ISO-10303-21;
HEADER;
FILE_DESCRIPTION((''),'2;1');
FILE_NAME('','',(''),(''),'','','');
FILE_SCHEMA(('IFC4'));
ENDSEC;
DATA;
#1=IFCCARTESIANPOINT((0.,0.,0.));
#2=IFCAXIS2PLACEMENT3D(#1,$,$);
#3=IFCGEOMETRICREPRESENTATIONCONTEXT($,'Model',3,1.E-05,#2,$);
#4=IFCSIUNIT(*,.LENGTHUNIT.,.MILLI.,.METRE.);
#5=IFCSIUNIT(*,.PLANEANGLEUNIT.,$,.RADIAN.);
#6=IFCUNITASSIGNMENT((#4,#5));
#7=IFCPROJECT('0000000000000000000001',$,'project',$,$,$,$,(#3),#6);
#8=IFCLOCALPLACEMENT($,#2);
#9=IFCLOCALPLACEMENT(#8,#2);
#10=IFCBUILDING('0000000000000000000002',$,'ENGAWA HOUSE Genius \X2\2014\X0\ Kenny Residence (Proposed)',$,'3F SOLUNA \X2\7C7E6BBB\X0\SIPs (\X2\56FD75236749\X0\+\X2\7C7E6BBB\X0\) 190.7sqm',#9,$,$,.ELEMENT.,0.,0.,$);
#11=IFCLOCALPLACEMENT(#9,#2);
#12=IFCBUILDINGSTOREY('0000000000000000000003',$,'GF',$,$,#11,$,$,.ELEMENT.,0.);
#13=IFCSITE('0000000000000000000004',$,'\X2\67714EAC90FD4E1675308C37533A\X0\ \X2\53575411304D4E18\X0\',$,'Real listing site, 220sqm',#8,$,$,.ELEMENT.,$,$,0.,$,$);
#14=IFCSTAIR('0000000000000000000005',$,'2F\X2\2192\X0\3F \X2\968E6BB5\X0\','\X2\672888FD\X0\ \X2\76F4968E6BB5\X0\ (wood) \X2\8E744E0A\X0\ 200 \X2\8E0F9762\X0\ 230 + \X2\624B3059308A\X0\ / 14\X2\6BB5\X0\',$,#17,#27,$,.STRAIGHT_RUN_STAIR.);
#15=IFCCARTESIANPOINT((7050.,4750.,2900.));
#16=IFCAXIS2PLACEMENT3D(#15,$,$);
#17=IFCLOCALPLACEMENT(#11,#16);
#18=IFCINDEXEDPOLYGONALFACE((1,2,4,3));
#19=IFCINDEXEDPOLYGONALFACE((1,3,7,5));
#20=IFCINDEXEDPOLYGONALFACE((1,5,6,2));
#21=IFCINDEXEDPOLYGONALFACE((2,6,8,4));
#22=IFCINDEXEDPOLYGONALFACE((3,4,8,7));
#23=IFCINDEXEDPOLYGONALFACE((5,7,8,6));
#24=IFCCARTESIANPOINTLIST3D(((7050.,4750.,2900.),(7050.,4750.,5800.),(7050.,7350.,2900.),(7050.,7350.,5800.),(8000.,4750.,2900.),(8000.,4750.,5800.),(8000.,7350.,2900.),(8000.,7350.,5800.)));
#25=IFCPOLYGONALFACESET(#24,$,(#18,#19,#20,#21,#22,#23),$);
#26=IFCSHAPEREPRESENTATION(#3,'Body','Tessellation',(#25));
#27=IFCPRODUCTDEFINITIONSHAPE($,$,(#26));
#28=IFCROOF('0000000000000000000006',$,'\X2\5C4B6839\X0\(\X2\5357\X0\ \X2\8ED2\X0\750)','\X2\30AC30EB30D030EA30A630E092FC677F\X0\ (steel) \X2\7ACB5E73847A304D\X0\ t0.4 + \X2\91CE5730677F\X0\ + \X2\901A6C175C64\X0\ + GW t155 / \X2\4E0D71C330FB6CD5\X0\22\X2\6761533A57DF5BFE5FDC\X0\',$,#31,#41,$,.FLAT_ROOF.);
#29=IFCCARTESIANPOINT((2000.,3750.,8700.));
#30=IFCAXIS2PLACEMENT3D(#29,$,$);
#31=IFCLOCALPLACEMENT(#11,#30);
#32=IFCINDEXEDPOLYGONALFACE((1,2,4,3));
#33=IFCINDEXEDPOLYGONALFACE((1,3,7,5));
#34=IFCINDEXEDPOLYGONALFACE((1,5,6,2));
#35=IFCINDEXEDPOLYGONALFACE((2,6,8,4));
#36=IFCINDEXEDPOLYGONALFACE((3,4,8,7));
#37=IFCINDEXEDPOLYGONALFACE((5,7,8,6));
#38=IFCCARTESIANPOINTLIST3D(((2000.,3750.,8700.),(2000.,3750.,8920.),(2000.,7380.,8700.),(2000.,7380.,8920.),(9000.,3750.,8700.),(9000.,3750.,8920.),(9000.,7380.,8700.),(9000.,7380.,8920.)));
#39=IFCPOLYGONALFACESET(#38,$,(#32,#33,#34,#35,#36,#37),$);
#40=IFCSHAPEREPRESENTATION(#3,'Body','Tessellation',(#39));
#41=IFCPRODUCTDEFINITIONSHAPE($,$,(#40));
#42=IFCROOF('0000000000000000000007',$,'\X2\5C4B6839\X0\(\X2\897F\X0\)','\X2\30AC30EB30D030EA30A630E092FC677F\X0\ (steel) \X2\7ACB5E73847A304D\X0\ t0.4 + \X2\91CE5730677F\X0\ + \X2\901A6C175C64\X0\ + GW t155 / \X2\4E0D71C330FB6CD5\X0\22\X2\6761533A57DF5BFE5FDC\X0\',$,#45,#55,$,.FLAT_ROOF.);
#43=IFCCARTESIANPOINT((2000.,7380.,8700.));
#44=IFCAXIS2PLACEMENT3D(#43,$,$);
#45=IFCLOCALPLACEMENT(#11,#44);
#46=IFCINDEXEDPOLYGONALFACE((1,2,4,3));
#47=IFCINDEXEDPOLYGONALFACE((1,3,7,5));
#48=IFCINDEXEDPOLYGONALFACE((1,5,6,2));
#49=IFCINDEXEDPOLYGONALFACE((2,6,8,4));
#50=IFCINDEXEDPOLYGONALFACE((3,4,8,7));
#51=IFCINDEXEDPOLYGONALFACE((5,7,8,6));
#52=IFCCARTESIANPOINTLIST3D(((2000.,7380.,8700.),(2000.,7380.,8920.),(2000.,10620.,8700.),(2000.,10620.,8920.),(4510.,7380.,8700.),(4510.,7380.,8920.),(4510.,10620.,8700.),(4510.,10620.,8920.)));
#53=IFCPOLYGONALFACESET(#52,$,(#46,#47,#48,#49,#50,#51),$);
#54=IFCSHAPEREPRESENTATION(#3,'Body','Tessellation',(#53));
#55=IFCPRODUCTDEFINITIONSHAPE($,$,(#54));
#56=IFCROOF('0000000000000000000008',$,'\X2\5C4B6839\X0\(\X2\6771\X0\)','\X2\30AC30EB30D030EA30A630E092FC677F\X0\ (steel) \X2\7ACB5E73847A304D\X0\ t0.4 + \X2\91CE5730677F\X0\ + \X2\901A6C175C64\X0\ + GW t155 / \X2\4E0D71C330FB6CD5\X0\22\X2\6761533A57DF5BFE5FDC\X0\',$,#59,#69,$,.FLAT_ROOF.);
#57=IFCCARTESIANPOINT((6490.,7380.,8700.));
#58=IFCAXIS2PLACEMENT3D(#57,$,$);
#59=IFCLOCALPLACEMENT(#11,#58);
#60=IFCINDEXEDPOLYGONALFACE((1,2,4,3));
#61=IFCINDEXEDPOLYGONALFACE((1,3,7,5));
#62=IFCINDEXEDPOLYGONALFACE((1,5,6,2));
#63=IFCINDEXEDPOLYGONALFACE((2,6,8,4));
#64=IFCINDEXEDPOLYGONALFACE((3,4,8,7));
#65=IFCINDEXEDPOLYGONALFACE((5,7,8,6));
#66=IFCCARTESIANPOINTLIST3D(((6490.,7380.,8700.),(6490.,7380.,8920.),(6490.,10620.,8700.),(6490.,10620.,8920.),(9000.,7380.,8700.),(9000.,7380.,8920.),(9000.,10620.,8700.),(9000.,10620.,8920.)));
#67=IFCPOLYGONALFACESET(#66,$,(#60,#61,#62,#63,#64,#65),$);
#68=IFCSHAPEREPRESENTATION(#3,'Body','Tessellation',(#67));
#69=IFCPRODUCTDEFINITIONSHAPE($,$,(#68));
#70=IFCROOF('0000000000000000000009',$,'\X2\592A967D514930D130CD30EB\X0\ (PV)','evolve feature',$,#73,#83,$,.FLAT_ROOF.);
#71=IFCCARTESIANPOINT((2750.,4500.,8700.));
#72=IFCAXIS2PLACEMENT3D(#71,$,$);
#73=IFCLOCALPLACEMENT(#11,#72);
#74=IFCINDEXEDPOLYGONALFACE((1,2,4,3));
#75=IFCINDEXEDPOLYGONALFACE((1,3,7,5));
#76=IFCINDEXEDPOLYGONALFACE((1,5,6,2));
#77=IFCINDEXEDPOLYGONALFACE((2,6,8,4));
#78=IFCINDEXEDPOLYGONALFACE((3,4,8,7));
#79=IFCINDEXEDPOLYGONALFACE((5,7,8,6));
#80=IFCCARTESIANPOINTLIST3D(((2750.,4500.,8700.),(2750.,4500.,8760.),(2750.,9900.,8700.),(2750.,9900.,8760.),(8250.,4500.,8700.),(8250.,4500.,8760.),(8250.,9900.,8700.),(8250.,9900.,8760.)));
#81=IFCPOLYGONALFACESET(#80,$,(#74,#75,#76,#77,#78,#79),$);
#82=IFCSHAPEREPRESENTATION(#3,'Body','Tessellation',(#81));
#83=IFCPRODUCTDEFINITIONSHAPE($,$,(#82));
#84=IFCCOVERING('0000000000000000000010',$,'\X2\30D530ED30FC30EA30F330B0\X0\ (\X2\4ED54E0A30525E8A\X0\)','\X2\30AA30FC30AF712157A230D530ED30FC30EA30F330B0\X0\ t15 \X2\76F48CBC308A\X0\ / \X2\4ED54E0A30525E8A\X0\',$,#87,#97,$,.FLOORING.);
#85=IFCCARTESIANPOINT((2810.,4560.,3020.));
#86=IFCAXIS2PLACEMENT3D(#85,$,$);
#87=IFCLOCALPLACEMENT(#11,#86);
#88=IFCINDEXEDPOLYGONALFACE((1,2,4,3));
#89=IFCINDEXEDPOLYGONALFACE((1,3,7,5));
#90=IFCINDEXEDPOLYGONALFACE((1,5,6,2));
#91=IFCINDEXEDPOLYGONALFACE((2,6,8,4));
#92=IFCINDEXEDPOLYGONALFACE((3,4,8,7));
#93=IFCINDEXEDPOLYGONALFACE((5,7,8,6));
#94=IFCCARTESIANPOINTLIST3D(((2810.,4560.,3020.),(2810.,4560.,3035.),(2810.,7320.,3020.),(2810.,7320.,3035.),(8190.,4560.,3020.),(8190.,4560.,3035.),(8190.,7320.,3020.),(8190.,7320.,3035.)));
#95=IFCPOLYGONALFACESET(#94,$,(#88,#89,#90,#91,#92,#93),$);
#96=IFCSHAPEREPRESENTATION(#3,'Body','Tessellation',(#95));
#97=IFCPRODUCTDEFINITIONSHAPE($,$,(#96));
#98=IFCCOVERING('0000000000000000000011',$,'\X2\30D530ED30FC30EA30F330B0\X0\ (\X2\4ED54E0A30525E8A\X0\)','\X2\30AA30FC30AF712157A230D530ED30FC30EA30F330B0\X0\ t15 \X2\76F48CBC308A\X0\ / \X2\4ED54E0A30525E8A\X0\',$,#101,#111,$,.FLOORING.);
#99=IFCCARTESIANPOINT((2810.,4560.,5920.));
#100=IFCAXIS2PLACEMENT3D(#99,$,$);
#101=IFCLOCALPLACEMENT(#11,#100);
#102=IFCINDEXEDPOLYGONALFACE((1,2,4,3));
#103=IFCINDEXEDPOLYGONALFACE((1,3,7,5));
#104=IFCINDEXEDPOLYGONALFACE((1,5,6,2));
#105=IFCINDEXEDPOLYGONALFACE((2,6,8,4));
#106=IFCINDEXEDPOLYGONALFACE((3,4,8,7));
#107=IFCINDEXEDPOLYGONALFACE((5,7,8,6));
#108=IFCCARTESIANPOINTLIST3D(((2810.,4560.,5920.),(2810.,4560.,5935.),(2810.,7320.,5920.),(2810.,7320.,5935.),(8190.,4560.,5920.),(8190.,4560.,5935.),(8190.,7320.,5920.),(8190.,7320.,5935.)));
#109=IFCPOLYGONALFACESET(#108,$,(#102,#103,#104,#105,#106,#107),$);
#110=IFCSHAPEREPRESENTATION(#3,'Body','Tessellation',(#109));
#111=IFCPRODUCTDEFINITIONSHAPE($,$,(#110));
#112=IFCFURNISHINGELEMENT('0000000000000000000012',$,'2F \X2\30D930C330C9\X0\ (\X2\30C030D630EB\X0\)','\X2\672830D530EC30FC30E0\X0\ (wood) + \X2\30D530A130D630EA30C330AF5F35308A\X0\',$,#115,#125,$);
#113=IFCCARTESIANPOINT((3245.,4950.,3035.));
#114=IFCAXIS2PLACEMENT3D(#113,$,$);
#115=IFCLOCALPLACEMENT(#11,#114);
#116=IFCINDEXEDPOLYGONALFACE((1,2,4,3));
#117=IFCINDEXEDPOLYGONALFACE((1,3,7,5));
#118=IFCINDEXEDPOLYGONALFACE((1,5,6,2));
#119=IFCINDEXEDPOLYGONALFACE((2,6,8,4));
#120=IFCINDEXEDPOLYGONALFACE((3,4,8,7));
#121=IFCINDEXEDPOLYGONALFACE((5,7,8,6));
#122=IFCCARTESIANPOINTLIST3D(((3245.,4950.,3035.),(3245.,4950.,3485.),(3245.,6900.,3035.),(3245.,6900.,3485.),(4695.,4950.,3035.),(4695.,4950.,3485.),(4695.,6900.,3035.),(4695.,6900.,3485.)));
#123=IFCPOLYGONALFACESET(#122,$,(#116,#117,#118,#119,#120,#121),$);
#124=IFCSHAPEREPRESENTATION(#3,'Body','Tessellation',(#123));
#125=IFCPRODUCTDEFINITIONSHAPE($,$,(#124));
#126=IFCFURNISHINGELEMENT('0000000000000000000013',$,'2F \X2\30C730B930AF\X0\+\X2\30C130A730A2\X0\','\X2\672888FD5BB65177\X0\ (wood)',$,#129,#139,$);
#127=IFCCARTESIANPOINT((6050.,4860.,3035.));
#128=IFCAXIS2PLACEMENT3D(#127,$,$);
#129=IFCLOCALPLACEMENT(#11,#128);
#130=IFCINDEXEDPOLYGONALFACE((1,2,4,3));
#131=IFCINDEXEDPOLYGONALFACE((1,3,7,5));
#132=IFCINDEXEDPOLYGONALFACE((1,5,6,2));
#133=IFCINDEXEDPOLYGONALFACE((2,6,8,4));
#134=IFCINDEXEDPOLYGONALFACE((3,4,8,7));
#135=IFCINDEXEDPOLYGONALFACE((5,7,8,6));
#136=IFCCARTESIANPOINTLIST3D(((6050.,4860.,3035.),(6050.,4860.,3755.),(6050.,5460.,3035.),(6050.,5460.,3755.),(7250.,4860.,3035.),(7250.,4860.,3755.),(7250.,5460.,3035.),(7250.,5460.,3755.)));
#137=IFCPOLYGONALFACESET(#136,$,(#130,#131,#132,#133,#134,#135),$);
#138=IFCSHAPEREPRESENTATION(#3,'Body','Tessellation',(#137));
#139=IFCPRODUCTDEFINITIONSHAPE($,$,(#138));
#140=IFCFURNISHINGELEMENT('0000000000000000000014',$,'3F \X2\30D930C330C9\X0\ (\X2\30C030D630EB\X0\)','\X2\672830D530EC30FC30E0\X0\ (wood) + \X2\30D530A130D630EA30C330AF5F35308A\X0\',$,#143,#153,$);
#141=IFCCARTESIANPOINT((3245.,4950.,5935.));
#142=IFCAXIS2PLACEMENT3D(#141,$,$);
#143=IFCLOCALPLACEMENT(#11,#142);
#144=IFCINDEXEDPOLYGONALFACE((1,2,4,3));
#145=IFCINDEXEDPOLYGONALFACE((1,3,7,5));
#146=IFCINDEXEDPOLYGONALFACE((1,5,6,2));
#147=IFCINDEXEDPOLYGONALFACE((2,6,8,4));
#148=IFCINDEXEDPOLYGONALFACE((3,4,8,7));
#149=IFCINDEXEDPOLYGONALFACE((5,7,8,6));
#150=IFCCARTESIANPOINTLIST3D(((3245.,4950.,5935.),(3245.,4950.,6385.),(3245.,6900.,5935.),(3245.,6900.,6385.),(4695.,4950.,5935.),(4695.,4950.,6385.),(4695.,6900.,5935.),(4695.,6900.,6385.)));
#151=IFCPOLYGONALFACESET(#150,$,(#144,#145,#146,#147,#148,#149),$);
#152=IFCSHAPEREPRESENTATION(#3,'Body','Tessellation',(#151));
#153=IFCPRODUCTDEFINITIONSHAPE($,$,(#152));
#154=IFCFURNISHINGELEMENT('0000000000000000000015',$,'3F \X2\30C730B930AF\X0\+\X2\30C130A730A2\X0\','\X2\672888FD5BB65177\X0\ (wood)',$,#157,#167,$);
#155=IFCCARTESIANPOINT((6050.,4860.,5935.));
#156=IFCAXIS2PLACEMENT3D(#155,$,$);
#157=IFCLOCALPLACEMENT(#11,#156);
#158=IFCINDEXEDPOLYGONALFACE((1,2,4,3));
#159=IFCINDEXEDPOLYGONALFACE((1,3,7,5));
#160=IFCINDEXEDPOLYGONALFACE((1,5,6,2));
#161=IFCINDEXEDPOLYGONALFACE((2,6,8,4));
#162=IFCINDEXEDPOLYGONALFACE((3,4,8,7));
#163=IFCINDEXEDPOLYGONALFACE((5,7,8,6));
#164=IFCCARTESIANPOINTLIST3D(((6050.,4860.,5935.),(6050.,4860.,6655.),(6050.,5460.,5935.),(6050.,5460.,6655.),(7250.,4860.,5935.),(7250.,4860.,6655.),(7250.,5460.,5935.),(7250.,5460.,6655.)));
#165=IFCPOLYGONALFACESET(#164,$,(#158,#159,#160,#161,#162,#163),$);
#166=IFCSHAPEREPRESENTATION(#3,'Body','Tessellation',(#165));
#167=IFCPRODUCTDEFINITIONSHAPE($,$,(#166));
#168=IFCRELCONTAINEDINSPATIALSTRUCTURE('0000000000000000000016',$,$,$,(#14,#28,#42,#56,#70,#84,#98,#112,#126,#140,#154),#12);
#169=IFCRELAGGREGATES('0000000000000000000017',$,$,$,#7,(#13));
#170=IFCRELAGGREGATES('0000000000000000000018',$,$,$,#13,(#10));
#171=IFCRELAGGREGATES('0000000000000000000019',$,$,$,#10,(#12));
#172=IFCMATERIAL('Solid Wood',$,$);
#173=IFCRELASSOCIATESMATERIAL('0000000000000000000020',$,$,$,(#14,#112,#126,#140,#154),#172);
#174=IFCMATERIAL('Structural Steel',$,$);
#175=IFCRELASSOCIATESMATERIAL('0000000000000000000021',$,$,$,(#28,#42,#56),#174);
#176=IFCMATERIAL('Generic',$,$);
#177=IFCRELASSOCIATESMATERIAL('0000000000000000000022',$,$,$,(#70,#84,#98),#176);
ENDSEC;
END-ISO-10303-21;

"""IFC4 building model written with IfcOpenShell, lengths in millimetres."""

from ifc_helpers import new_model, si_unit, frame, frame_2d, origin, place, context, project, spatial, rectangle, extrude, material, element, save


model = new_model("IFC4")

# Units and contexts
model_context = context("Model", 3, precision=1e-05, world=origin())
ifc_project = project(units=[si_unit("LENGTHUNIT", "METRE", prefix="MILLI"), si_unit("PLANEANGLEUNIT", "RADIAN")], contexts=[model_context])

# Site, building, storey
site_placement = place(None, origin())
site = spatial("IfcSite", under=ifc_project, at=site_placement, Name="東京都世田谷区 南向き丘", ObjectType="Real listing site, 220sqm", CompositionType="ELEMENT", RefElevation=0.0)
building_placement = place(site_placement, origin())
building = spatial("IfcBuilding", under=site, at=building_placement, Name="ENGAWA HOUSE Genius — Kenny Residence (Proposed)", ObjectType="3F SOLUNA 籾殻SIPs (国産杉+籾殻) 190.7sqm", CompositionType="ELEMENT", ElevationOfRefHeight=0.0, ElevationOfTerrain=0.0)
storey_placement = place(building_placement, origin())
storey = spatial("IfcBuildingStorey", under=building, at=storey_placement, Name="GF", CompositionType="ELEMENT", Elevation=0.0)

# Shared definitions
ifc_material_1 = material(Name="Solid Wood")

# Stair
stair_placement = place(storey_placement, frame((7050.0, 4750.0, 2900.0)))
element("IfcStair", 1, at=stair_placement, inside=storey, material=ifc_material_1, Name="2F→3F 階段", Description="木製 直階段 (wood) 蹴上 200 踏面 230 + 手すり / 14段", PredefinedType="STRAIGHT_RUN_STAIR", context=model_context, shape_type="SweptSolid", body=[
    extrude(rectangle(XDim=950.0, YDim=2600.0, at=frame_2d((475.0, 1300.0))), frame((7050.0, 4750.0, 2900.0)), (0.0, 0.0, 1.0), 2900.0),
])

# Roofs
ifc_material_2 = material(Name="Structural Steel")
roof_1_placement = place(storey_placement, frame((2000.0, 3750.0, 8700.0)))
element("IfcRoof", 2, at=roof_1_placement, inside=storey, material=ifc_material_2, Name="屋根(南 軒750)", Description="ガルバリウム鋼板 (steel) 立平葺き t0.4 + 野地板 + 通気層 + GW t155 / 不燃・法22条区域対応", PredefinedType="FLAT_ROOF", context=model_context, shape_type="SweptSolid", body=[
    extrude(rectangle(XDim=7000.0, YDim=3630.0, at=frame_2d((3500.0, 1815.0))), frame((2000.0, 3750.0, 8700.0)), (0.0, 0.0, 1.0), 220.0),
])
roof_2_placement = place(storey_placement, frame((2000.0, 7380.0, 8700.0)))
element("IfcRoof", 3, at=roof_2_placement, inside=storey, material=ifc_material_2, Name="屋根(西)", Description="ガルバリウム鋼板 (steel) 立平葺き t0.4 + 野地板 + 通気層 + GW t155 / 不燃・法22条区域対応", PredefinedType="FLAT_ROOF", context=model_context, shape_type="SweptSolid", body=[
    extrude(rectangle(XDim=2510.0, YDim=3240.0, at=frame_2d((1255.0, 1620.0))), frame((2000.0, 7380.0, 8700.0)), (0.0, 0.0, 1.0), 220.0),
])
roof_3_placement = place(storey_placement, frame((6490.0, 7380.0, 8700.0)))
element("IfcRoof", 4, at=roof_3_placement, inside=storey, material=ifc_material_2, Name="屋根(東)", Description="ガルバリウム鋼板 (steel) 立平葺き t0.4 + 野地板 + 通気層 + GW t155 / 不燃・法22条区域対応", PredefinedType="FLAT_ROOF", context=model_context, shape_type="SweptSolid", body=[
    extrude(rectangle(XDim=2510.0, YDim=3240.0, at=frame_2d((1255.0, 1620.0))), frame((6490.0, 7380.0, 8700.0)), (0.0, 0.0, 1.0), 220.0),
])
ifc_material_3 = material(Name="Generic")
roof_4_placement = place(storey_placement, frame((2750.0, 4500.0, 8700.0)))
element("IfcRoof", 5, at=roof_4_placement, inside=storey, material=ifc_material_3, Name="太陽光パネル (PV)", Description="evolve feature", PredefinedType="FLAT_ROOF", context=model_context, shape_type="SweptSolid", body=[
    extrude(rectangle(XDim=5500.0, YDim=5400.0, at=frame_2d((2750.0, 2700.0))), frame((2750.0, 4500.0, 8700.0)), (0.0, 0.0, 1.0), 60.0),
])

# Coverings
covering_1_placement = place(storey_placement, frame((2810.0, 4560.0, 3020.0)))
element("IfcCovering", 6, at=covering_1_placement, inside=storey, material=ifc_material_3, Name="フローリング (仕上げ床)", Description="オーク無垢フローリング t15 直貼り / 仕上げ床", PredefinedType="FLOORING", context=model_context, shape_type="SweptSolid", body=[
    extrude(rectangle(XDim=5380.0, YDim=2760.0, at=frame_2d((2690.0, 1380.0))), frame((2810.0, 4560.0, 3020.0)), (0.0, 0.0, 1.0), 15.0),
])
covering_2_placement = place(storey_placement, frame((2810.0, 4560.0, 5920.0)))
element("IfcCovering", 7, at=covering_2_placement, inside=storey, material=ifc_material_3, Name="フローリング (仕上げ床)", Description="オーク無垢フローリング t15 直貼り / 仕上げ床", PredefinedType="FLOORING", context=model_context, shape_type="SweptSolid", body=[
    extrude(rectangle(XDim=5380.0, YDim=2760.0, at=frame_2d((2690.0, 1380.0))), frame((2810.0, 4560.0, 5920.0)), (0.0, 0.0, 1.0), 15.0),
])

# Furnishing elements
furnishing_1_placement = place(storey_placement, frame((3245.0, 4950.0, 3035.0)))
element("IfcFurnishingElement", 8, at=furnishing_1_placement, inside=storey, material=ifc_material_1, Name="2F ベッド (ダブル)", Description="木フレーム (wood) + ファブリック張り", context=model_context, shape_type="SweptSolid", body=[
    extrude(rectangle(XDim=1450.0, YDim=1950.0, at=frame_2d((725.0, 975.0))), frame((3245.0, 4950.0, 3035.0)), (0.0, 0.0, 1.0), 450.0),
])
furnishing_2_placement = place(storey_placement, frame((6050.0, 4860.0, 3035.0)))
element("IfcFurnishingElement", 9, at=furnishing_2_placement, inside=storey, material=ifc_material_1, Name="2F デスク+チェア", Description="木製家具 (wood)", context=model_context, shape_type="SweptSolid", body=[
    extrude(rectangle(XDim=1200.0, YDim=600.0, at=frame_2d((600.0, 300.0))), frame((6050.0, 4860.0, 3035.0)), (0.0, 0.0, 1.0), 720.0),
])
furnishing_3_placement = place(storey_placement, frame((3245.0, 4950.0, 5935.0)))
element("IfcFurnishingElement", 10, at=furnishing_3_placement, inside=storey, material=ifc_material_1, Name="3F ベッド (ダブル)", Description="木フレーム (wood) + ファブリック張り", context=model_context, shape_type="SweptSolid", body=[
    extrude(rectangle(XDim=1450.0, YDim=1950.0, at=frame_2d((725.0, 975.0))), frame((3245.0, 4950.0, 5935.0)), (0.0, 0.0, 1.0), 450.0),
])
furnishing_4_placement = place(storey_placement, frame((6050.0, 4860.0, 5935.0)))
element("IfcFurnishingElement", 11, at=furnishing_4_placement, inside=storey, material=ifc_material_1, Name="3F デスク+チェア", Description="木製家具 (wood)", context=model_context, shape_type="SweptSolid", body=[
    extrude(rectangle(XDim=1200.0, YDim=600.0, at=frame_2d((600.0, 300.0))), frame((6050.0, 4860.0, 5935.0)), (0.0, 0.0, 1.0), 720.0),
])

save(model, "model.ifc")
